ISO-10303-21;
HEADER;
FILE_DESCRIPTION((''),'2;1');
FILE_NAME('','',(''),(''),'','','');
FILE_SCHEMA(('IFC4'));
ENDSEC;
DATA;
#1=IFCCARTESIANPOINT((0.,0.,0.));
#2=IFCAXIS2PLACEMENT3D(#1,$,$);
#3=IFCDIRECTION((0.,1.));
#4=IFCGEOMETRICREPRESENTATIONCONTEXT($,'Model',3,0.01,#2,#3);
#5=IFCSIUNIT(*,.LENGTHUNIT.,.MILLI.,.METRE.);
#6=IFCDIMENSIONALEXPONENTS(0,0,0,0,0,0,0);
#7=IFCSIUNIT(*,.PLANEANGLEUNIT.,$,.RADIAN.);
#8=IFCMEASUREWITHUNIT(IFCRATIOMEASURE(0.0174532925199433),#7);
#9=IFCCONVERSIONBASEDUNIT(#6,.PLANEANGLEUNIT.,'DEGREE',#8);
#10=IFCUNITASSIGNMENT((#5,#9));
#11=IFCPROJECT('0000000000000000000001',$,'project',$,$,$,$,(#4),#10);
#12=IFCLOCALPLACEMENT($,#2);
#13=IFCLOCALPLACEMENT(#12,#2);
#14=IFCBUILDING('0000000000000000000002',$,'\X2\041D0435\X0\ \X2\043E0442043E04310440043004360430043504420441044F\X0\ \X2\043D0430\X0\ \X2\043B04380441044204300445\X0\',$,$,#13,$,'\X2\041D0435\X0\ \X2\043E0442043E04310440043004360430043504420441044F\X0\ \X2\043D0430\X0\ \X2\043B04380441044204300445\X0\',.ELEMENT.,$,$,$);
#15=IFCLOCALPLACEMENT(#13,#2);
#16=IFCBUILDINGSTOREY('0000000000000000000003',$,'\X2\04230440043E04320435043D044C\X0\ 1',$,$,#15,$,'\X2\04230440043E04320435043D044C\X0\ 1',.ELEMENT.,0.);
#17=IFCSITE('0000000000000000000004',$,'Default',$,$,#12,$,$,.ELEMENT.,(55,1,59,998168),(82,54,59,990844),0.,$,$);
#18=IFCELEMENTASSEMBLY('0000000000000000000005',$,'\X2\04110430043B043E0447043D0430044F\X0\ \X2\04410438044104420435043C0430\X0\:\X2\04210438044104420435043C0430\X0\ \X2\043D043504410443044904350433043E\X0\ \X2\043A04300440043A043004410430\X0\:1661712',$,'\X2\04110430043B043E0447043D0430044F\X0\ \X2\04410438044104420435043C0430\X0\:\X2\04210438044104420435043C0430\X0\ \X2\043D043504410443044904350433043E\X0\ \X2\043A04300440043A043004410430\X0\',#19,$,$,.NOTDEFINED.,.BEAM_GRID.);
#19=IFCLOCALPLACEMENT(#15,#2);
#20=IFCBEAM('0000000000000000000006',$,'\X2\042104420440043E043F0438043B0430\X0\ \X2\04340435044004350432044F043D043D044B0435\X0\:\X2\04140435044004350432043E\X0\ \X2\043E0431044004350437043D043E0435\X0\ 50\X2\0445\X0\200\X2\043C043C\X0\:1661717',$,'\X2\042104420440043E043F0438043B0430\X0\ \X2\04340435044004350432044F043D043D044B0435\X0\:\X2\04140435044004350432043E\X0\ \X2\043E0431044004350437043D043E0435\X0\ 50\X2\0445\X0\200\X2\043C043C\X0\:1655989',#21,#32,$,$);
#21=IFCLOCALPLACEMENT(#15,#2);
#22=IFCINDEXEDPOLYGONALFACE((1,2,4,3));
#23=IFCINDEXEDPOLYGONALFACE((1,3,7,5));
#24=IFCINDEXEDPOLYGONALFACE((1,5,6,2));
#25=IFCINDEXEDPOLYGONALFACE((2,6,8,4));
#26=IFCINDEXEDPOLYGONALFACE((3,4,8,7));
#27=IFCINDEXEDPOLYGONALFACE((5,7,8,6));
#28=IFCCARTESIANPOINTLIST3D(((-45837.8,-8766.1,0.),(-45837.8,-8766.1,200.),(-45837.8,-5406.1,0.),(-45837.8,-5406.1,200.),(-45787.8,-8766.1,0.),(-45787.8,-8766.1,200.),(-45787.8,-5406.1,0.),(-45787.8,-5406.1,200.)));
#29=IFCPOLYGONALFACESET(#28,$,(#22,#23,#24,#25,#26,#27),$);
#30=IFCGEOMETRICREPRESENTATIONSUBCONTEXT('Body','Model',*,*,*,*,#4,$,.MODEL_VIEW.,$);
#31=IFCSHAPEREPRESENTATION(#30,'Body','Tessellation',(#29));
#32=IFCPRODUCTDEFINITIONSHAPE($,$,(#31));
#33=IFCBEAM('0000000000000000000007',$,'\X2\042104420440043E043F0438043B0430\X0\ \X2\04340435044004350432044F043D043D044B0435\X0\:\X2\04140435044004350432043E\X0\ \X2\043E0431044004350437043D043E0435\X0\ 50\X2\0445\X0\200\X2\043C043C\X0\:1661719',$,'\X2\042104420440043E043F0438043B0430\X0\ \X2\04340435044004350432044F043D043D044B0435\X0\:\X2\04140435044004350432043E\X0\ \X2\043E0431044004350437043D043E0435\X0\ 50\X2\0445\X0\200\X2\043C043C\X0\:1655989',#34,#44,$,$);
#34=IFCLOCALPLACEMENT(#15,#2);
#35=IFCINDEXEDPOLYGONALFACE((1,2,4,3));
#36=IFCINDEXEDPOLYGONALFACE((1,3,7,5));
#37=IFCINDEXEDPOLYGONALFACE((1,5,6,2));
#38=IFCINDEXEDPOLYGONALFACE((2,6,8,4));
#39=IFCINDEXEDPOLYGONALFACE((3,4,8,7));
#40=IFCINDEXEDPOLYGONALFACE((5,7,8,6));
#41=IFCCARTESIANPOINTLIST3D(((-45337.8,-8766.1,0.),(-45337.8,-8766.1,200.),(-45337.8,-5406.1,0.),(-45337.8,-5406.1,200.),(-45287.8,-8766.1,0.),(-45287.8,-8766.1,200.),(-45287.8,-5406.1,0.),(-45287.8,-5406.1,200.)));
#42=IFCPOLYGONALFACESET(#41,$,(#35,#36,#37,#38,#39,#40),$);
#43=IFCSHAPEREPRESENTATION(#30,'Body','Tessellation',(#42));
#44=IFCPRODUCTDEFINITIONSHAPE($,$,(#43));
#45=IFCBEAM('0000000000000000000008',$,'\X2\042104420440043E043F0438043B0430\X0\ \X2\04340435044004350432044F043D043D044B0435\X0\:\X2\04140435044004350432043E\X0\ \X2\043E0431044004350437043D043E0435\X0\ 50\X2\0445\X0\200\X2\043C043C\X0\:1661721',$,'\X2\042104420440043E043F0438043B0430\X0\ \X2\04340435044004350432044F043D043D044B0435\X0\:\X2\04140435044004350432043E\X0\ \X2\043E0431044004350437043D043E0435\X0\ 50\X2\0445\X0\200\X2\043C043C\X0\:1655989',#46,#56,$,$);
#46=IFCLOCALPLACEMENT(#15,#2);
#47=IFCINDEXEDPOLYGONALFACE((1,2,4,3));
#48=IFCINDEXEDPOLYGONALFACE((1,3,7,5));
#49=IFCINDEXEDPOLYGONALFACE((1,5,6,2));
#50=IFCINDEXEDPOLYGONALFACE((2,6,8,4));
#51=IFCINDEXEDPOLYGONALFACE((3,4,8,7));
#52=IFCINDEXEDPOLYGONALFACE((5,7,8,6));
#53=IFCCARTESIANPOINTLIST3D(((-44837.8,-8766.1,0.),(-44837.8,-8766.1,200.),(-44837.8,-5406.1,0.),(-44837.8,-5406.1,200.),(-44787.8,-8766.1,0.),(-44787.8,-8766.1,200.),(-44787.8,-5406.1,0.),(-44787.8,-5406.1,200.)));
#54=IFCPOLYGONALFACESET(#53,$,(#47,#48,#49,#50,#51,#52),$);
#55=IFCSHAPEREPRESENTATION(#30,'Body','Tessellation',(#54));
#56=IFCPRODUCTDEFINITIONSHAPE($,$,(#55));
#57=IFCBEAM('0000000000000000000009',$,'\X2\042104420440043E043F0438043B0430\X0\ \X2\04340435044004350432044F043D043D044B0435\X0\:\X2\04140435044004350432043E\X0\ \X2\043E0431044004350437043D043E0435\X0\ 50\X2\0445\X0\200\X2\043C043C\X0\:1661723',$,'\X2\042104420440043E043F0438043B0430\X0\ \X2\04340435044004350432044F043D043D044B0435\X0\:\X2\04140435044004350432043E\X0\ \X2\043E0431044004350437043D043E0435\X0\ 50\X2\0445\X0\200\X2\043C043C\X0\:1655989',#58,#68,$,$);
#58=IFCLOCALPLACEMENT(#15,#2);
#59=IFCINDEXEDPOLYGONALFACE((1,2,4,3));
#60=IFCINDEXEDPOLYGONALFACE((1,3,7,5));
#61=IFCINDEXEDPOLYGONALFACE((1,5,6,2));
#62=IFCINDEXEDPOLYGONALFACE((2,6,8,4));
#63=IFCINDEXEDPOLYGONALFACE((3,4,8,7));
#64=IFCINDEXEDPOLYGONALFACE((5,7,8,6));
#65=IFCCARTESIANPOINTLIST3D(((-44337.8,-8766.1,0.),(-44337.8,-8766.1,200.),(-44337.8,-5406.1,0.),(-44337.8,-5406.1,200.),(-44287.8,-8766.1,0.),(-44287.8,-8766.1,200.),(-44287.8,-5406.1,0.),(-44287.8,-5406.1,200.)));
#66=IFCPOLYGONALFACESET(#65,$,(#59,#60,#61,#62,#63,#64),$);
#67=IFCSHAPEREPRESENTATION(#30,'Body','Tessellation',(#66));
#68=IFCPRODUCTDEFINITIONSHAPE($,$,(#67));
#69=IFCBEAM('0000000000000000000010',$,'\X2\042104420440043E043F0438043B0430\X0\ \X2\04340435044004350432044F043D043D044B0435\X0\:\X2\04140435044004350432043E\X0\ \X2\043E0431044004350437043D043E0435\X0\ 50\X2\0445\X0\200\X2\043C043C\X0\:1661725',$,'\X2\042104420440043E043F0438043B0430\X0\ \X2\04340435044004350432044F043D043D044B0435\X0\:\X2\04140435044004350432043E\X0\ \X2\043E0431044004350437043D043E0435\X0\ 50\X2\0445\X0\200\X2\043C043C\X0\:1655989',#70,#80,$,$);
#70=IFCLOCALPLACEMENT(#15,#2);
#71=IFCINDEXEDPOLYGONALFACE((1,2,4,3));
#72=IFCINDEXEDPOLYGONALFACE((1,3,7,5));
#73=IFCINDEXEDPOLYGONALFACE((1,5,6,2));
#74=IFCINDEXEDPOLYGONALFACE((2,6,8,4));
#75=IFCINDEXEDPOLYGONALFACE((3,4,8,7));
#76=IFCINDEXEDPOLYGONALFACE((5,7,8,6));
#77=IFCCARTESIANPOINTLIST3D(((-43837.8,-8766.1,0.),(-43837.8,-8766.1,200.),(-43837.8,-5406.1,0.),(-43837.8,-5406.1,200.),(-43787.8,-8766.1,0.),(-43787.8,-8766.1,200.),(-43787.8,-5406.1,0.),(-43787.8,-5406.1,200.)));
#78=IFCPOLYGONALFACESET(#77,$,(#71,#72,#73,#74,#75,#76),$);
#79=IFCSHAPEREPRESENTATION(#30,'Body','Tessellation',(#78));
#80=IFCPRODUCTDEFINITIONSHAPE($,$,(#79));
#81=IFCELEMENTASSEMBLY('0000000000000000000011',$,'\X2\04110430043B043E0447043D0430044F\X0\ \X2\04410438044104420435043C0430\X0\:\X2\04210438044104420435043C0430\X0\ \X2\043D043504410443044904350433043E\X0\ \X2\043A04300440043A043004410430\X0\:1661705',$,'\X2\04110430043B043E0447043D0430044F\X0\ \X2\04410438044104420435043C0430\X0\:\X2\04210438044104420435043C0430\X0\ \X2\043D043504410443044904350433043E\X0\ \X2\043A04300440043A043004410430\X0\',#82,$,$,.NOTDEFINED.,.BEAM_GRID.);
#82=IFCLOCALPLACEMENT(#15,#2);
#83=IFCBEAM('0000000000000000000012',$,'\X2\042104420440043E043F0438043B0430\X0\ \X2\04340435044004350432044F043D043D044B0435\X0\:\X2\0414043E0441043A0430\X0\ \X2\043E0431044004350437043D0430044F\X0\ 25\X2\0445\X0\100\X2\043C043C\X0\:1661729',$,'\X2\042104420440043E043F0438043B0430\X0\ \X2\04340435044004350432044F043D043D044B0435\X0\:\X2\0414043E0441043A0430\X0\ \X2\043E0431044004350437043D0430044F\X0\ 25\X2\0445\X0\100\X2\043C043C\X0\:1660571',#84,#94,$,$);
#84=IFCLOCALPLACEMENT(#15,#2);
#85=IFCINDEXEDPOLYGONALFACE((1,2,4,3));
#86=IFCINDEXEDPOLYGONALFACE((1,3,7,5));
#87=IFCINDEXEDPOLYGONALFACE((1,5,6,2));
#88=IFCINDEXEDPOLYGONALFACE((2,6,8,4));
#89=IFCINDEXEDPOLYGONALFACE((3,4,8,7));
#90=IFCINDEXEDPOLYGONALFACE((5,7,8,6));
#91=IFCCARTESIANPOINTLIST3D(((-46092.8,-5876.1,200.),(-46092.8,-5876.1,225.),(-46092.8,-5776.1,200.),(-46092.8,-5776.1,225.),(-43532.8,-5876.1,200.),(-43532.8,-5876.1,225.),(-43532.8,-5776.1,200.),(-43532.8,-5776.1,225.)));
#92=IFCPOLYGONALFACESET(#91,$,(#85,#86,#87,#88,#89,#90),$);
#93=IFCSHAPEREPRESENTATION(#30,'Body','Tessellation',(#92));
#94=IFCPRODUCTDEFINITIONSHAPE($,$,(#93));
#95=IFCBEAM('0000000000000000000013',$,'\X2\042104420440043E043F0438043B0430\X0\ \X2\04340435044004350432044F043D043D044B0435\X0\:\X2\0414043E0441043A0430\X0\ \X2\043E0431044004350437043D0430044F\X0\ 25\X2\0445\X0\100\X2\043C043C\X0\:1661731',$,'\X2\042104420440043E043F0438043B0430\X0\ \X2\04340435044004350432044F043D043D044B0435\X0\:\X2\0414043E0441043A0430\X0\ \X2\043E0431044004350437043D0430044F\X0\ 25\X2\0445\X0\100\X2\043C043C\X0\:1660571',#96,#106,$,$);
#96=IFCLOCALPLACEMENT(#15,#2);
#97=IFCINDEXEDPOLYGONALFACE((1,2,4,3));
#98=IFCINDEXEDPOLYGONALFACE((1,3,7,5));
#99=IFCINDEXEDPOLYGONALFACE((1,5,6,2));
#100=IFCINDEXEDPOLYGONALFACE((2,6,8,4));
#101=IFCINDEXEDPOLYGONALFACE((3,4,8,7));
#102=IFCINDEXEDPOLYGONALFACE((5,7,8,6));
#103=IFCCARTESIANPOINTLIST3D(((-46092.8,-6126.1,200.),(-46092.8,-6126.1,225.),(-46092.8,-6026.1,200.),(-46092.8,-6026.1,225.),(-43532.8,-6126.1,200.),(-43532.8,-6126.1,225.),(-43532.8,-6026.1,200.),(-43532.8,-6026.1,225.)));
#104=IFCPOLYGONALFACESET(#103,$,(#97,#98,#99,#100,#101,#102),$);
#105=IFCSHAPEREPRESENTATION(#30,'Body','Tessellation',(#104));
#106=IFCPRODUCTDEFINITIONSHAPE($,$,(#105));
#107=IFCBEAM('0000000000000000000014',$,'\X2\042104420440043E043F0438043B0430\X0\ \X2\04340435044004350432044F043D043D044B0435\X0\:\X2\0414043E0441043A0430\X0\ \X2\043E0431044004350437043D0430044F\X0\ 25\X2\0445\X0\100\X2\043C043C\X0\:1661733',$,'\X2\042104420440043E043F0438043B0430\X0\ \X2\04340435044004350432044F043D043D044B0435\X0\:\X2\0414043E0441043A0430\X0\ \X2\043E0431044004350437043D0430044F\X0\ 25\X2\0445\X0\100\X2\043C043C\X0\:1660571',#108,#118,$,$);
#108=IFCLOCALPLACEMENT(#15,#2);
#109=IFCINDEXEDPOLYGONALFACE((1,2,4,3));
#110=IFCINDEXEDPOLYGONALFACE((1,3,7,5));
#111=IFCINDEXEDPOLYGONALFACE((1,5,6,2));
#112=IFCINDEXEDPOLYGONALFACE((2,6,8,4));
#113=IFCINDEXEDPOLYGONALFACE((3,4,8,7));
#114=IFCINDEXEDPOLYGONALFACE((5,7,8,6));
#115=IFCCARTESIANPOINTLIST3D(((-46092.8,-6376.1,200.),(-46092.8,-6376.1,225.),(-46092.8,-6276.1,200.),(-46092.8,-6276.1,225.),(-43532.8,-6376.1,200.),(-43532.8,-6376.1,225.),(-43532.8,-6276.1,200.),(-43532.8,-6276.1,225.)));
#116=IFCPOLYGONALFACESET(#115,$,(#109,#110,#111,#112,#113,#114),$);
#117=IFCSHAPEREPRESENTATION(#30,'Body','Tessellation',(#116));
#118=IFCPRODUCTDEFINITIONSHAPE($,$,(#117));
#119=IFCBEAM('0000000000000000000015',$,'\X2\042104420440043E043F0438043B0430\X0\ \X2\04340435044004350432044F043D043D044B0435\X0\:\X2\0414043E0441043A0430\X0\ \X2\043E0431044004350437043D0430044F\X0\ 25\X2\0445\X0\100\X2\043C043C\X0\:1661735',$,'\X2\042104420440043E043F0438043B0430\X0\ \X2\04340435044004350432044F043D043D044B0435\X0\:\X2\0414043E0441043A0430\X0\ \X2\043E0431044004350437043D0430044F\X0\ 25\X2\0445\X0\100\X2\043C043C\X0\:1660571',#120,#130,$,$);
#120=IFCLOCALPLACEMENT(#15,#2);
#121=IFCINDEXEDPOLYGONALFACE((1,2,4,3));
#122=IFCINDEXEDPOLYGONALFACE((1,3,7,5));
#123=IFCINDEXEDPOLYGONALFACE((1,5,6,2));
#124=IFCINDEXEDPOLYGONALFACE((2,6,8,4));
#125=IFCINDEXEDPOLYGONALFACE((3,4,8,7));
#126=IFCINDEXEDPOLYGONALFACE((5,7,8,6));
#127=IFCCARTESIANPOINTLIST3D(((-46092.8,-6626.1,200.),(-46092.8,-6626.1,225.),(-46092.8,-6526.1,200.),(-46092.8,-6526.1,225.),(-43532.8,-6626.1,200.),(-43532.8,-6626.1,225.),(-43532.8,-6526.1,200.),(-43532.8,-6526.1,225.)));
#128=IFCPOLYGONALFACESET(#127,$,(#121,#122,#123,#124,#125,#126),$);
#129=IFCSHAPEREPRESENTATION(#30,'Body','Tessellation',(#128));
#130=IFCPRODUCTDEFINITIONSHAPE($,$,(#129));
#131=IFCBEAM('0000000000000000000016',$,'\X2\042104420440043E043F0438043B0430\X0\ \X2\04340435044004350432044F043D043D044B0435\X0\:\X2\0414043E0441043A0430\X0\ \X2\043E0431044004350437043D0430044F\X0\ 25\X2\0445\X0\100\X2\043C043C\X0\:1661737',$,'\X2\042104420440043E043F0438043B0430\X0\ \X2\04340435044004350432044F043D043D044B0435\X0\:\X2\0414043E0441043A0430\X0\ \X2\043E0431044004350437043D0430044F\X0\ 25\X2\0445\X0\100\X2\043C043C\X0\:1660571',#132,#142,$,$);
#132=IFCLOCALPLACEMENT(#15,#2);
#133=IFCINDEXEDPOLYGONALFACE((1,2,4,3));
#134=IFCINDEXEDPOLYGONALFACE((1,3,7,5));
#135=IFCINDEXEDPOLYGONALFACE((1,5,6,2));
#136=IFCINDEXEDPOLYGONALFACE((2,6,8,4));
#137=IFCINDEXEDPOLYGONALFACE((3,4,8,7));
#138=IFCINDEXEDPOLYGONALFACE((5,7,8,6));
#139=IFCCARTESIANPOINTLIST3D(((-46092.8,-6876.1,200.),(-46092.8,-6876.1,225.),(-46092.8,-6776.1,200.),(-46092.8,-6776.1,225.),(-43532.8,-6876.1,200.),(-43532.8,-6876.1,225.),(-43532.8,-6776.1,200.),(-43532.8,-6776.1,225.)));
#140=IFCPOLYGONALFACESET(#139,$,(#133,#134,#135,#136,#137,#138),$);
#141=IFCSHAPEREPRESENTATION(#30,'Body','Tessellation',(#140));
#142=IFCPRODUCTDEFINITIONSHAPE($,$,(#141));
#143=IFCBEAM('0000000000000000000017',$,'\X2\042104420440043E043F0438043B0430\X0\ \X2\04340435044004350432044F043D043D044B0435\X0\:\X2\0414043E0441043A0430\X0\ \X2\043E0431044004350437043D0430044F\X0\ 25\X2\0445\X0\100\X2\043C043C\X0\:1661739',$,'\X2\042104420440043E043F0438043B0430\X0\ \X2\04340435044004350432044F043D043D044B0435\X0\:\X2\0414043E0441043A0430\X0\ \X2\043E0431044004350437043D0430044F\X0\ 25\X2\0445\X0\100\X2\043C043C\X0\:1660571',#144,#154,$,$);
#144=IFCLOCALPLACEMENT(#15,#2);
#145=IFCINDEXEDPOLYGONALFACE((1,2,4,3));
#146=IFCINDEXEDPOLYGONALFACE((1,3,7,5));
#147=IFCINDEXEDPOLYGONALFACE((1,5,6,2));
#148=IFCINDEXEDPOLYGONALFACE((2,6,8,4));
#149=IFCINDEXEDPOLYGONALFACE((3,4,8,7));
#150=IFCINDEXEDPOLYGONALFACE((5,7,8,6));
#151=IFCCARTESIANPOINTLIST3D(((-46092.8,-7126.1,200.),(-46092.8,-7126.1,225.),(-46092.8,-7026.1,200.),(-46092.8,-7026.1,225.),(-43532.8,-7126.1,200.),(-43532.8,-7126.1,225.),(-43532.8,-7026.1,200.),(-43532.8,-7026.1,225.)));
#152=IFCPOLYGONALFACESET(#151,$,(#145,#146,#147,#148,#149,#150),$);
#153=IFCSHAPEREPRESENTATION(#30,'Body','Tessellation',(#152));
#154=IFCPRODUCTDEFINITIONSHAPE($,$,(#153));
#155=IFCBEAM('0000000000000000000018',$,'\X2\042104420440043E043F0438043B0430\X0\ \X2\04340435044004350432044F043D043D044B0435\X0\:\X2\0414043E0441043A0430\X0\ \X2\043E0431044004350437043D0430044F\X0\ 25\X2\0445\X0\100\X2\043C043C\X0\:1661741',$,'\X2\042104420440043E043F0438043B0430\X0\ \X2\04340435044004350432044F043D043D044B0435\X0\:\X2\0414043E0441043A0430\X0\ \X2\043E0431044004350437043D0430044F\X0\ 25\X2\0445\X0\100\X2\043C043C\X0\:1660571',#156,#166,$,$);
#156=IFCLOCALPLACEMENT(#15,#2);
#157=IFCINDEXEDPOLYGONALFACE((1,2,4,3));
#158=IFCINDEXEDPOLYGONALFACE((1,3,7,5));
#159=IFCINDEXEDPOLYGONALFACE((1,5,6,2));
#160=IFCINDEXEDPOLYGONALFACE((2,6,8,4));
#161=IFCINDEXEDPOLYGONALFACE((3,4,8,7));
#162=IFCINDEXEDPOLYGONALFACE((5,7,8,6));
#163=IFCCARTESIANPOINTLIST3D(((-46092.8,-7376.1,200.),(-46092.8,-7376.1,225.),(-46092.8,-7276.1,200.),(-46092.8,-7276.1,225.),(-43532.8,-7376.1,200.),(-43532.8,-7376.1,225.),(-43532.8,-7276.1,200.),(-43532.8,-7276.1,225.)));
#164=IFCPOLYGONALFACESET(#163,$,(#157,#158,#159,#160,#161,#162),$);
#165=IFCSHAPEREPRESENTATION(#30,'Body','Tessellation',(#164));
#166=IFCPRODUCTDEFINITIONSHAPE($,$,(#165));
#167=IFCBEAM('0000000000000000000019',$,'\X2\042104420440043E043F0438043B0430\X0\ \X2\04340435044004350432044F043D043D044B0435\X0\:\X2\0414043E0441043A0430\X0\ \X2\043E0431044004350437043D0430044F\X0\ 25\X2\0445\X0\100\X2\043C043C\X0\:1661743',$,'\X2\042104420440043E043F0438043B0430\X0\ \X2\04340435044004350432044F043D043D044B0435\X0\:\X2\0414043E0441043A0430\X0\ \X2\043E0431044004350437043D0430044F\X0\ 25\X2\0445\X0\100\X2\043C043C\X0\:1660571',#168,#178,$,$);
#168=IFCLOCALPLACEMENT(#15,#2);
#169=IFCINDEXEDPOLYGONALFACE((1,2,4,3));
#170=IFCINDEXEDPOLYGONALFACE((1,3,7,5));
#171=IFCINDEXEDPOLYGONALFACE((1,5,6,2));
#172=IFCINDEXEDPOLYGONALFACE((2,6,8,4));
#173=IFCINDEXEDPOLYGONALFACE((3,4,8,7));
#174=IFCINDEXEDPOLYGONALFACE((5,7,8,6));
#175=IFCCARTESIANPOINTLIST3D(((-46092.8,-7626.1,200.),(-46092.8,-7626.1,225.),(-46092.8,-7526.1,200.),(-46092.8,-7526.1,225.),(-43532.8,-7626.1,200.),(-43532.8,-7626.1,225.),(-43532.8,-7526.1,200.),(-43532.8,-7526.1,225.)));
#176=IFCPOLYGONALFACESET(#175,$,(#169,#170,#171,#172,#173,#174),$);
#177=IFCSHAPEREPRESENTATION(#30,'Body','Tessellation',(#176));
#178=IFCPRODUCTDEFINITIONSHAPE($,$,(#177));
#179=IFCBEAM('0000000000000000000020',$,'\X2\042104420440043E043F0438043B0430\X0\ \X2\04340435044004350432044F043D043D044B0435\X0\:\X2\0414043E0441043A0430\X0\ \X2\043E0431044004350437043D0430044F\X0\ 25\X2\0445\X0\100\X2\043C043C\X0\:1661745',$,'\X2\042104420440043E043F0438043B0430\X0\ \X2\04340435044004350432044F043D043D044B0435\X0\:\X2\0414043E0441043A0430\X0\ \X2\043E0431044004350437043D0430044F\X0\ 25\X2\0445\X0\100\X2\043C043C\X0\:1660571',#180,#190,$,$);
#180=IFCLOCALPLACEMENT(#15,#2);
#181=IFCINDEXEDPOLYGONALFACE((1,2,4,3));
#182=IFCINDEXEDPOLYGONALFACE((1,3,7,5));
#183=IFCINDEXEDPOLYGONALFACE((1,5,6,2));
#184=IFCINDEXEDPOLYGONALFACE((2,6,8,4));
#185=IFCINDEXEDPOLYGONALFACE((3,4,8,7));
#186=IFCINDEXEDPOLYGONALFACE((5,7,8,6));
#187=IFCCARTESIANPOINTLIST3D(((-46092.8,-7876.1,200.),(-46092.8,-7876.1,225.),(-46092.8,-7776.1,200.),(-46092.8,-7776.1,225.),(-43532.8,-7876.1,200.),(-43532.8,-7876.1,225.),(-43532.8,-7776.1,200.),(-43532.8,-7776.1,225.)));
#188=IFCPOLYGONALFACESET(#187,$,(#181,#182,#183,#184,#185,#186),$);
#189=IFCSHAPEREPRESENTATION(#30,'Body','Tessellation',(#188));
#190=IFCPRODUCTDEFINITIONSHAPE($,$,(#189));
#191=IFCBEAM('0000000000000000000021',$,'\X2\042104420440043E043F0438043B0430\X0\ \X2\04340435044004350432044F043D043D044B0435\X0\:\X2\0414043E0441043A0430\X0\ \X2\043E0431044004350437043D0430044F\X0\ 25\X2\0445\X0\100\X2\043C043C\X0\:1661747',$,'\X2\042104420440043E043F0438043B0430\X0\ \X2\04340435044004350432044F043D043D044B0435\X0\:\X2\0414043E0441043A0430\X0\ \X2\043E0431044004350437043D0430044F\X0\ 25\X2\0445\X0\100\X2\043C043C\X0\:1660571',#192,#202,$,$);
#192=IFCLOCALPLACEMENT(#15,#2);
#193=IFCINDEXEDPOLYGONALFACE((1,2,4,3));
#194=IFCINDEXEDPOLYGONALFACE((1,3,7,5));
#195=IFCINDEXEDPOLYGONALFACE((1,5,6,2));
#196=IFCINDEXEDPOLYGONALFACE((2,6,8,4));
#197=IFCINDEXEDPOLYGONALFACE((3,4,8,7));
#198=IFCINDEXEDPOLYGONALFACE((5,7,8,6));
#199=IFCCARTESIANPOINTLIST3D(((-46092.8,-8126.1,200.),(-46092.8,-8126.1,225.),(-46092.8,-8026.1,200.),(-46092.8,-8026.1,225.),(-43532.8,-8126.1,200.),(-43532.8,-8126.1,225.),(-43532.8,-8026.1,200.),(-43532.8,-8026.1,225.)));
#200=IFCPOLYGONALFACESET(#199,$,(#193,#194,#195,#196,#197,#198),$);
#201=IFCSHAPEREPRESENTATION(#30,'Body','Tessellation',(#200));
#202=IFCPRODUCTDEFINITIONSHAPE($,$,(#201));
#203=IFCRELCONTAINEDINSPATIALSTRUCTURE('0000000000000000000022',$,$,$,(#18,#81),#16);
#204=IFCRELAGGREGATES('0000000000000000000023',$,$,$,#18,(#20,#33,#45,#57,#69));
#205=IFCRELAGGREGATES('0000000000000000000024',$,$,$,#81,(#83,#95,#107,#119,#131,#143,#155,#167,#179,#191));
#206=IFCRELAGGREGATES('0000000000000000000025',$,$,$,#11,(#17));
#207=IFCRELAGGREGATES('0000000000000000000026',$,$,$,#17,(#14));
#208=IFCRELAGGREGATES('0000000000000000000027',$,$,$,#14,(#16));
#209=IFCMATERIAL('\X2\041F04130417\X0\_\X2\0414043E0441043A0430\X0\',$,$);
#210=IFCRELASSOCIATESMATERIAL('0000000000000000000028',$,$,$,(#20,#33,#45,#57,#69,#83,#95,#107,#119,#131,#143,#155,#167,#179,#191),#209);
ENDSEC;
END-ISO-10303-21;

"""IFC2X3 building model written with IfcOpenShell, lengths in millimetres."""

from ifc_helpers import new_model, entity, si_unit, converted_unit, direction, frame, frame_2d, origin, place, context, subcontext, project, spatial, rectangle, extrude, material, element, aggregate, save


model = new_model("IFC2X3")

# Units and contexts
model_context = context("Model", 3, precision=0.01, world=origin(), true_north=direction((0.0, 1.0)))
body_context = subcontext(model_context, "Body", "Model", "MODEL_VIEW")
ifc_project = project(units=[si_unit("LENGTHUNIT", "METRE", prefix="MILLI"), converted_unit("PLANEANGLEUNIT", "DEGREE", entity("IfcRatioMeasure", 0.0174532925199433), si_unit("PLANEANGLEUNIT", "RADIAN"), dimensions=[0, 0, 0, 0, 0, 0, 0])], contexts=[model_context])

# Site, building, storey
site_placement = place(None, origin())
site = spatial("IfcSite", under=ifc_project, at=site_placement, Name="Default", CompositionType="ELEMENT", RefLatitude=(55, 1, 59, 998168), RefLongitude=(82, 54, 59, 990844), RefElevation=0.0)
building_placement = place(site_placement, origin())
building = spatial("IfcBuilding", under=site, at=building_placement, Name="Не отображается на листах", LongName="Не отображается на листах", CompositionType="ELEMENT")
storey_placement = place(building_placement, frame((0.0, 0.0, 0.0)))
storey = spatial("IfcBuildingStorey", under=building, at=storey_placement, Name="Уровень 1", LongName="Уровень 1", CompositionType="ELEMENT", Elevation=0.0)

# Element assemblies, beams
assembly_1_placement = place(storey_placement, origin())
assembly_1 = element("IfcElementAssembly", 1, at=assembly_1_placement, inside=storey, Name="Балочная система:Система несущего каркаса:1661712", ObjectType="Балочная система:Система несущего каркаса", AssemblyPlace="NOTDEFINED", PredefinedType="BEAM_GRID")
ifc_material_1 = material(Name="ПГЗ_Доска")
beam_1_placement = place(assembly_1_placement, frame((-45812.8, -8766.1, 0.0), z_axis=(0.0, 0.0, 1.0), x_axis=(0.0, 1.0, 0.0)))
beam_1 = element("IfcBeam", 2, at=beam_1_placement, material=ifc_material_1, Name="Стропила деревянные:Дерево обрезное 50х200мм:1661717", ObjectType="Стропила деревянные:Дерево обрезное 50х200мм:1655989", context=body_context, shape_type="SweptSolid", body=[
    extrude(rectangle(XDim=200.0, YDim=50.0, at=frame_2d((0.0, 0.0), x_axis=(1.0, 0.0))), frame((0.0, 0.0, 100.0), z_axis=(1.0, 0.0, 0.0), x_axis=(0.0, 0.0, -1.0)), (0.0, 0.0, 1.0), 3360.0),
])
beam_2_placement = place(assembly_1_placement, frame((-45312.8, -8766.1, 0.0), z_axis=(0.0, 0.0, 1.0), x_axis=(0.0, 1.0, 0.0)))
beam_2 = element("IfcBeam", 3, at=beam_2_placement, material=ifc_material_1, Name="Стропила деревянные:Дерево обрезное 50х200мм:1661719", ObjectType="Стропила деревянные:Дерево обрезное 50х200мм:1655989", context=body_context, shape_type="SweptSolid", body=[
    extrude(rectangle(XDim=200.0, YDim=50.0, at=frame_2d((0.0, 0.0), x_axis=(1.0, 0.0))), frame((0.0, 0.0, 100.0), z_axis=(1.0, 0.0, 0.0), x_axis=(0.0, 0.0, -1.0)), (0.0, 0.0, 1.0), 3360.0),
])
beam_3_placement = place(assembly_1_placement, frame((-44812.8, -8766.1, 0.0), z_axis=(0.0, 0.0, 1.0), x_axis=(0.0, 1.0, 0.0)))
beam_3 = element("IfcBeam", 4, at=beam_3_placement, material=ifc_material_1, Name="Стропила деревянные:Дерево обрезное 50х200мм:1661721", ObjectType="Стропила деревянные:Дерево обрезное 50х200мм:1655989", context=body_context, shape_type="SweptSolid", body=[
    extrude(rectangle(XDim=200.0, YDim=50.0, at=frame_2d((0.0, 0.0), x_axis=(1.0, 0.0))), frame((0.0, 0.0, 100.0), z_axis=(1.0, 0.0, 0.0), x_axis=(0.0, 0.0, -1.0)), (0.0, 0.0, 1.0), 3360.0),
])
beam_4_placement = place(assembly_1_placement, frame((-44312.8, -8766.1, 0.0), z_axis=(0.0, 0.0, 1.0), x_axis=(0.0, 1.0, 0.0)))
beam_4 = element("IfcBeam", 5, at=beam_4_placement, material=ifc_material_1, Name="Стропила деревянные:Дерево обрезное 50х200мм:1661723", ObjectType="Стропила деревянные:Дерево обрезное 50х200мм:1655989", context=body_context, shape_type="SweptSolid", body=[
    extrude(rectangle(XDim=200.0, YDim=50.0, at=frame_2d((0.0, 0.0), x_axis=(1.0, 0.0))), frame((0.0, 0.0, 100.0), z_axis=(1.0, 0.0, 0.0), x_axis=(0.0, 0.0, -1.0)), (0.0, 0.0, 1.0), 3360.0),
])
beam_5_placement = place(assembly_1_placement, frame((-43812.8, -8766.1, 0.0), z_axis=(0.0, 0.0, 1.0), x_axis=(0.0, 1.0, 0.0)))
beam_5 = element("IfcBeam", 6, at=beam_5_placement, material=ifc_material_1, Name="Стропила деревянные:Дерево обрезное 50х200мм:1661725", ObjectType="Стропила деревянные:Дерево обрезное 50х200мм:1655989", context=body_context, shape_type="SweptSolid", body=[
    extrude(rectangle(XDim=200.0, YDim=50.0, at=frame_2d((0.0, 0.0), x_axis=(1.0, 0.0))), frame((0.0, 0.0, 100.0), z_axis=(1.0, 0.0, 0.0), x_axis=(0.0, 0.0, -1.0)), (0.0, 0.0, 1.0), 3360.0),
])
aggregate(assembly_1, [beam_1, beam_2, beam_3, beam_4, beam_5])
assembly_2_placement = place(storey_placement, origin())
assembly_2 = element("IfcElementAssembly", 7, at=assembly_2_placement, inside=storey, Name="Балочная система:Система несущего каркаса:1661705", ObjectType="Балочная система:Система несущего каркаса", AssemblyPlace="NOTDEFINED", PredefinedType="BEAM_GRID")
beam_6_placement = place(assembly_2_placement, frame((-46092.8, -5826.1, 0.0)))
beam_6 = element("IfcBeam", 8, at=beam_6_placement, material=ifc_material_1, Name="Стропила деревянные:Доска обрезная 25х100мм:1661729", ObjectType="Стропила деревянные:Доска обрезная 25х100мм:1660571", context=body_context, shape_type="SweptSolid", body=[
    extrude(rectangle(XDim=25.0, YDim=100.0, at=frame_2d((0.0, 0.0), x_axis=(1.0, 0.0))), frame((0.0, 0.0, 212.5), z_axis=(1.0, 0.0, 0.0), x_axis=(0.0, 0.0, -1.0)), (0.0, 0.0, 1.0), 2560.0),
])
beam_7_placement = place(assembly_2_placement, frame((-46092.8, -6076.1, 0.0)))
beam_7 = element("IfcBeam", 9, at=beam_7_placement, material=ifc_material_1, Name="Стропила деревянные:Доска обрезная 25х100мм:1661731", ObjectType="Стропила деревянные:Доска обрезная 25х100мм:1660571", context=body_context, shape_type="SweptSolid", body=[
    extrude(rectangle(XDim=25.0, YDim=100.0, at=frame_2d((0.0, 0.0), x_axis=(1.0, 0.0))), frame((0.0, 0.0, 212.5), z_axis=(1.0, 0.0, 0.0), x_axis=(0.0, 0.0, -1.0)), (0.0, 0.0, 1.0), 2560.0),
])
beam_8_placement = place(assembly_2_placement, frame((-46092.8, -6326.1, 0.0)))
beam_8 = element("IfcBeam", 10, at=beam_8_placement, material=ifc_material_1, Name="Стропила деревянные:Доска обрезная 25х100мм:1661733", ObjectType="Стропила деревянные:Доска обрезная 25х100мм:1660571", context=body_context, shape_type="SweptSolid", body=[
    extrude(rectangle(XDim=25.0, YDim=100.0, at=frame_2d((0.0, 0.0), x_axis=(1.0, 0.0))), frame((0.0, 0.0, 212.5), z_axis=(1.0, 0.0, 0.0), x_axis=(0.0, 0.0, -1.0)), (0.0, 0.0, 1.0), 2560.0),
])
beam_9_placement = place(assembly_2_placement, frame((-46092.8, -6576.1, 0.0)))
beam_9 = element("IfcBeam", 11, at=beam_9_placement, material=ifc_material_1, Name="Стропила деревянные:Доска обрезная 25х100мм:1661735", ObjectType="Стропила деревянные:Доска обрезная 25х100мм:1660571", context=body_context, shape_type="SweptSolid", body=[
    extrude(rectangle(XDim=25.0, YDim=100.0, at=frame_2d((0.0, 0.0), x_axis=(1.0, 0.0))), frame((0.0, 0.0, 212.5), z_axis=(1.0, 0.0, 0.0), x_axis=(0.0, 0.0, -1.0)), (0.0, 0.0, 1.0), 2560.0),
])
beam_10_placement = place(assembly_2_placement, frame((-46092.8, -6826.1, 0.0)))
beam_10 = element("IfcBeam", 12, at=beam_10_placement, material=ifc_material_1, Name="Стропила деревянные:Доска обрезная 25х100мм:1661737", ObjectType="Стропила деревянные:Доска обрезная 25х100мм:1660571", context=body_context, shape_type="SweptSolid", body=[
    extrude(rectangle(XDim=25.0, YDim=100.0, at=frame_2d((0.0, 0.0), x_axis=(1.0, 0.0))), frame((0.0, 0.0, 212.5), z_axis=(1.0, 0.0, 0.0), x_axis=(0.0, 0.0, -1.0)), (0.0, 0.0, 1.0), 2560.0),
])
beam_11_placement = place(assembly_2_placement, frame((-46092.8, -7076.1, 0.0)))
beam_11 = element("IfcBeam", 13, at=beam_11_placement, material=ifc_material_1, Name="Стропила деревянные:Доска обрезная 25х100мм:1661739", ObjectType="Стропила деревянные:Доска обрезная 25х100мм:1660571", context=body_context, shape_type="SweptSolid", body=[
    extrude(rectangle(XDim=25.0, YDim=100.0, at=frame_2d((0.0, 0.0), x_axis=(1.0, 0.0))), frame((0.0, 0.0, 212.5), z_axis=(1.0, 0.0, 0.0), x_axis=(0.0, 0.0, -1.0)), (0.0, 0.0, 1.0), 2560.0),
])
beam_12_placement = place(assembly_2_placement, frame((-46092.8, -7326.1, 0.0)))
beam_12 = element("IfcBeam", 14, at=beam_12_placement, material=ifc_material_1, Name="Стропила деревянные:Доска обрезная 25х100мм:1661741", ObjectType="Стропила деревянные:Доска обрезная 25х100мм:1660571", context=body_context, shape_type="SweptSolid", body=[
    extrude(rectangle(XDim=25.0, YDim=100.0, at=frame_2d((0.0, 0.0), x_axis=(1.0, 0.0))), frame((0.0, 0.0, 212.5), z_axis=(1.0, 0.0, 0.0), x_axis=(0.0, 0.0, -1.0)), (0.0, 0.0, 1.0), 2560.0),
])
beam_13_placement = place(assembly_2_placement, frame((-46092.8, -7576.1, 0.0)))
beam_13 = element("IfcBeam", 15, at=beam_13_placement, material=ifc_material_1, Name="Стропила деревянные:Доска обрезная 25х100мм:1661743", ObjectType="Стропила деревянные:Доска обрезная 25х100мм:1660571", context=body_context, shape_type="SweptSolid", body=[
    extrude(rectangle(XDim=25.0, YDim=100.0, at=frame_2d((0.0, 0.0), x_axis=(1.0, 0.0))), frame((0.0, 0.0, 212.5), z_axis=(1.0, 0.0, 0.0), x_axis=(0.0, 0.0, -1.0)), (0.0, 0.0, 1.0), 2560.0),
])
beam_14_placement = place(assembly_2_placement, frame((-46092.8, -7826.1, 0.0)))
beam_14 = element("IfcBeam", 16, at=beam_14_placement, material=ifc_material_1, Name="Стропила деревянные:Доска обрезная 25х100мм:1661745", ObjectType="Стропила деревянные:Доска обрезная 25х100мм:1660571", context=body_context, shape_type="SweptSolid", body=[
    extrude(rectangle(XDim=25.0, YDim=100.0, at=frame_2d((0.0, 0.0), x_axis=(1.0, 0.0))), frame((0.0, 0.0, 212.5), z_axis=(1.0, 0.0, 0.0), x_axis=(0.0, 0.0, -1.0)), (0.0, 0.0, 1.0), 2560.0),
])
beam_15_placement = place(assembly_2_placement, frame((-46092.8, -8076.1, 0.0)))
beam_15 = element("IfcBeam", 17, at=beam_15_placement, material=ifc_material_1, Name="Стропила деревянные:Доска обрезная 25х100мм:1661747", ObjectType="Стропила деревянные:Доска обрезная 25х100мм:1660571", context=body_context, shape_type="SweptSolid", body=[
    extrude(rectangle(XDim=25.0, YDim=100.0, at=frame_2d((0.0, 0.0), x_axis=(1.0, 0.0))), frame((0.0, 0.0, 212.5), z_axis=(1.0, 0.0, 0.0), x_axis=(0.0, 0.0, -1.0)), (0.0, 0.0, 1.0), 2560.0),
])
aggregate(assembly_2, [beam_6, beam_7, beam_8, beam_9, beam_10, beam_11, beam_12, beam_13, beam_14, beam_15])

save(model, "model.ifc")
